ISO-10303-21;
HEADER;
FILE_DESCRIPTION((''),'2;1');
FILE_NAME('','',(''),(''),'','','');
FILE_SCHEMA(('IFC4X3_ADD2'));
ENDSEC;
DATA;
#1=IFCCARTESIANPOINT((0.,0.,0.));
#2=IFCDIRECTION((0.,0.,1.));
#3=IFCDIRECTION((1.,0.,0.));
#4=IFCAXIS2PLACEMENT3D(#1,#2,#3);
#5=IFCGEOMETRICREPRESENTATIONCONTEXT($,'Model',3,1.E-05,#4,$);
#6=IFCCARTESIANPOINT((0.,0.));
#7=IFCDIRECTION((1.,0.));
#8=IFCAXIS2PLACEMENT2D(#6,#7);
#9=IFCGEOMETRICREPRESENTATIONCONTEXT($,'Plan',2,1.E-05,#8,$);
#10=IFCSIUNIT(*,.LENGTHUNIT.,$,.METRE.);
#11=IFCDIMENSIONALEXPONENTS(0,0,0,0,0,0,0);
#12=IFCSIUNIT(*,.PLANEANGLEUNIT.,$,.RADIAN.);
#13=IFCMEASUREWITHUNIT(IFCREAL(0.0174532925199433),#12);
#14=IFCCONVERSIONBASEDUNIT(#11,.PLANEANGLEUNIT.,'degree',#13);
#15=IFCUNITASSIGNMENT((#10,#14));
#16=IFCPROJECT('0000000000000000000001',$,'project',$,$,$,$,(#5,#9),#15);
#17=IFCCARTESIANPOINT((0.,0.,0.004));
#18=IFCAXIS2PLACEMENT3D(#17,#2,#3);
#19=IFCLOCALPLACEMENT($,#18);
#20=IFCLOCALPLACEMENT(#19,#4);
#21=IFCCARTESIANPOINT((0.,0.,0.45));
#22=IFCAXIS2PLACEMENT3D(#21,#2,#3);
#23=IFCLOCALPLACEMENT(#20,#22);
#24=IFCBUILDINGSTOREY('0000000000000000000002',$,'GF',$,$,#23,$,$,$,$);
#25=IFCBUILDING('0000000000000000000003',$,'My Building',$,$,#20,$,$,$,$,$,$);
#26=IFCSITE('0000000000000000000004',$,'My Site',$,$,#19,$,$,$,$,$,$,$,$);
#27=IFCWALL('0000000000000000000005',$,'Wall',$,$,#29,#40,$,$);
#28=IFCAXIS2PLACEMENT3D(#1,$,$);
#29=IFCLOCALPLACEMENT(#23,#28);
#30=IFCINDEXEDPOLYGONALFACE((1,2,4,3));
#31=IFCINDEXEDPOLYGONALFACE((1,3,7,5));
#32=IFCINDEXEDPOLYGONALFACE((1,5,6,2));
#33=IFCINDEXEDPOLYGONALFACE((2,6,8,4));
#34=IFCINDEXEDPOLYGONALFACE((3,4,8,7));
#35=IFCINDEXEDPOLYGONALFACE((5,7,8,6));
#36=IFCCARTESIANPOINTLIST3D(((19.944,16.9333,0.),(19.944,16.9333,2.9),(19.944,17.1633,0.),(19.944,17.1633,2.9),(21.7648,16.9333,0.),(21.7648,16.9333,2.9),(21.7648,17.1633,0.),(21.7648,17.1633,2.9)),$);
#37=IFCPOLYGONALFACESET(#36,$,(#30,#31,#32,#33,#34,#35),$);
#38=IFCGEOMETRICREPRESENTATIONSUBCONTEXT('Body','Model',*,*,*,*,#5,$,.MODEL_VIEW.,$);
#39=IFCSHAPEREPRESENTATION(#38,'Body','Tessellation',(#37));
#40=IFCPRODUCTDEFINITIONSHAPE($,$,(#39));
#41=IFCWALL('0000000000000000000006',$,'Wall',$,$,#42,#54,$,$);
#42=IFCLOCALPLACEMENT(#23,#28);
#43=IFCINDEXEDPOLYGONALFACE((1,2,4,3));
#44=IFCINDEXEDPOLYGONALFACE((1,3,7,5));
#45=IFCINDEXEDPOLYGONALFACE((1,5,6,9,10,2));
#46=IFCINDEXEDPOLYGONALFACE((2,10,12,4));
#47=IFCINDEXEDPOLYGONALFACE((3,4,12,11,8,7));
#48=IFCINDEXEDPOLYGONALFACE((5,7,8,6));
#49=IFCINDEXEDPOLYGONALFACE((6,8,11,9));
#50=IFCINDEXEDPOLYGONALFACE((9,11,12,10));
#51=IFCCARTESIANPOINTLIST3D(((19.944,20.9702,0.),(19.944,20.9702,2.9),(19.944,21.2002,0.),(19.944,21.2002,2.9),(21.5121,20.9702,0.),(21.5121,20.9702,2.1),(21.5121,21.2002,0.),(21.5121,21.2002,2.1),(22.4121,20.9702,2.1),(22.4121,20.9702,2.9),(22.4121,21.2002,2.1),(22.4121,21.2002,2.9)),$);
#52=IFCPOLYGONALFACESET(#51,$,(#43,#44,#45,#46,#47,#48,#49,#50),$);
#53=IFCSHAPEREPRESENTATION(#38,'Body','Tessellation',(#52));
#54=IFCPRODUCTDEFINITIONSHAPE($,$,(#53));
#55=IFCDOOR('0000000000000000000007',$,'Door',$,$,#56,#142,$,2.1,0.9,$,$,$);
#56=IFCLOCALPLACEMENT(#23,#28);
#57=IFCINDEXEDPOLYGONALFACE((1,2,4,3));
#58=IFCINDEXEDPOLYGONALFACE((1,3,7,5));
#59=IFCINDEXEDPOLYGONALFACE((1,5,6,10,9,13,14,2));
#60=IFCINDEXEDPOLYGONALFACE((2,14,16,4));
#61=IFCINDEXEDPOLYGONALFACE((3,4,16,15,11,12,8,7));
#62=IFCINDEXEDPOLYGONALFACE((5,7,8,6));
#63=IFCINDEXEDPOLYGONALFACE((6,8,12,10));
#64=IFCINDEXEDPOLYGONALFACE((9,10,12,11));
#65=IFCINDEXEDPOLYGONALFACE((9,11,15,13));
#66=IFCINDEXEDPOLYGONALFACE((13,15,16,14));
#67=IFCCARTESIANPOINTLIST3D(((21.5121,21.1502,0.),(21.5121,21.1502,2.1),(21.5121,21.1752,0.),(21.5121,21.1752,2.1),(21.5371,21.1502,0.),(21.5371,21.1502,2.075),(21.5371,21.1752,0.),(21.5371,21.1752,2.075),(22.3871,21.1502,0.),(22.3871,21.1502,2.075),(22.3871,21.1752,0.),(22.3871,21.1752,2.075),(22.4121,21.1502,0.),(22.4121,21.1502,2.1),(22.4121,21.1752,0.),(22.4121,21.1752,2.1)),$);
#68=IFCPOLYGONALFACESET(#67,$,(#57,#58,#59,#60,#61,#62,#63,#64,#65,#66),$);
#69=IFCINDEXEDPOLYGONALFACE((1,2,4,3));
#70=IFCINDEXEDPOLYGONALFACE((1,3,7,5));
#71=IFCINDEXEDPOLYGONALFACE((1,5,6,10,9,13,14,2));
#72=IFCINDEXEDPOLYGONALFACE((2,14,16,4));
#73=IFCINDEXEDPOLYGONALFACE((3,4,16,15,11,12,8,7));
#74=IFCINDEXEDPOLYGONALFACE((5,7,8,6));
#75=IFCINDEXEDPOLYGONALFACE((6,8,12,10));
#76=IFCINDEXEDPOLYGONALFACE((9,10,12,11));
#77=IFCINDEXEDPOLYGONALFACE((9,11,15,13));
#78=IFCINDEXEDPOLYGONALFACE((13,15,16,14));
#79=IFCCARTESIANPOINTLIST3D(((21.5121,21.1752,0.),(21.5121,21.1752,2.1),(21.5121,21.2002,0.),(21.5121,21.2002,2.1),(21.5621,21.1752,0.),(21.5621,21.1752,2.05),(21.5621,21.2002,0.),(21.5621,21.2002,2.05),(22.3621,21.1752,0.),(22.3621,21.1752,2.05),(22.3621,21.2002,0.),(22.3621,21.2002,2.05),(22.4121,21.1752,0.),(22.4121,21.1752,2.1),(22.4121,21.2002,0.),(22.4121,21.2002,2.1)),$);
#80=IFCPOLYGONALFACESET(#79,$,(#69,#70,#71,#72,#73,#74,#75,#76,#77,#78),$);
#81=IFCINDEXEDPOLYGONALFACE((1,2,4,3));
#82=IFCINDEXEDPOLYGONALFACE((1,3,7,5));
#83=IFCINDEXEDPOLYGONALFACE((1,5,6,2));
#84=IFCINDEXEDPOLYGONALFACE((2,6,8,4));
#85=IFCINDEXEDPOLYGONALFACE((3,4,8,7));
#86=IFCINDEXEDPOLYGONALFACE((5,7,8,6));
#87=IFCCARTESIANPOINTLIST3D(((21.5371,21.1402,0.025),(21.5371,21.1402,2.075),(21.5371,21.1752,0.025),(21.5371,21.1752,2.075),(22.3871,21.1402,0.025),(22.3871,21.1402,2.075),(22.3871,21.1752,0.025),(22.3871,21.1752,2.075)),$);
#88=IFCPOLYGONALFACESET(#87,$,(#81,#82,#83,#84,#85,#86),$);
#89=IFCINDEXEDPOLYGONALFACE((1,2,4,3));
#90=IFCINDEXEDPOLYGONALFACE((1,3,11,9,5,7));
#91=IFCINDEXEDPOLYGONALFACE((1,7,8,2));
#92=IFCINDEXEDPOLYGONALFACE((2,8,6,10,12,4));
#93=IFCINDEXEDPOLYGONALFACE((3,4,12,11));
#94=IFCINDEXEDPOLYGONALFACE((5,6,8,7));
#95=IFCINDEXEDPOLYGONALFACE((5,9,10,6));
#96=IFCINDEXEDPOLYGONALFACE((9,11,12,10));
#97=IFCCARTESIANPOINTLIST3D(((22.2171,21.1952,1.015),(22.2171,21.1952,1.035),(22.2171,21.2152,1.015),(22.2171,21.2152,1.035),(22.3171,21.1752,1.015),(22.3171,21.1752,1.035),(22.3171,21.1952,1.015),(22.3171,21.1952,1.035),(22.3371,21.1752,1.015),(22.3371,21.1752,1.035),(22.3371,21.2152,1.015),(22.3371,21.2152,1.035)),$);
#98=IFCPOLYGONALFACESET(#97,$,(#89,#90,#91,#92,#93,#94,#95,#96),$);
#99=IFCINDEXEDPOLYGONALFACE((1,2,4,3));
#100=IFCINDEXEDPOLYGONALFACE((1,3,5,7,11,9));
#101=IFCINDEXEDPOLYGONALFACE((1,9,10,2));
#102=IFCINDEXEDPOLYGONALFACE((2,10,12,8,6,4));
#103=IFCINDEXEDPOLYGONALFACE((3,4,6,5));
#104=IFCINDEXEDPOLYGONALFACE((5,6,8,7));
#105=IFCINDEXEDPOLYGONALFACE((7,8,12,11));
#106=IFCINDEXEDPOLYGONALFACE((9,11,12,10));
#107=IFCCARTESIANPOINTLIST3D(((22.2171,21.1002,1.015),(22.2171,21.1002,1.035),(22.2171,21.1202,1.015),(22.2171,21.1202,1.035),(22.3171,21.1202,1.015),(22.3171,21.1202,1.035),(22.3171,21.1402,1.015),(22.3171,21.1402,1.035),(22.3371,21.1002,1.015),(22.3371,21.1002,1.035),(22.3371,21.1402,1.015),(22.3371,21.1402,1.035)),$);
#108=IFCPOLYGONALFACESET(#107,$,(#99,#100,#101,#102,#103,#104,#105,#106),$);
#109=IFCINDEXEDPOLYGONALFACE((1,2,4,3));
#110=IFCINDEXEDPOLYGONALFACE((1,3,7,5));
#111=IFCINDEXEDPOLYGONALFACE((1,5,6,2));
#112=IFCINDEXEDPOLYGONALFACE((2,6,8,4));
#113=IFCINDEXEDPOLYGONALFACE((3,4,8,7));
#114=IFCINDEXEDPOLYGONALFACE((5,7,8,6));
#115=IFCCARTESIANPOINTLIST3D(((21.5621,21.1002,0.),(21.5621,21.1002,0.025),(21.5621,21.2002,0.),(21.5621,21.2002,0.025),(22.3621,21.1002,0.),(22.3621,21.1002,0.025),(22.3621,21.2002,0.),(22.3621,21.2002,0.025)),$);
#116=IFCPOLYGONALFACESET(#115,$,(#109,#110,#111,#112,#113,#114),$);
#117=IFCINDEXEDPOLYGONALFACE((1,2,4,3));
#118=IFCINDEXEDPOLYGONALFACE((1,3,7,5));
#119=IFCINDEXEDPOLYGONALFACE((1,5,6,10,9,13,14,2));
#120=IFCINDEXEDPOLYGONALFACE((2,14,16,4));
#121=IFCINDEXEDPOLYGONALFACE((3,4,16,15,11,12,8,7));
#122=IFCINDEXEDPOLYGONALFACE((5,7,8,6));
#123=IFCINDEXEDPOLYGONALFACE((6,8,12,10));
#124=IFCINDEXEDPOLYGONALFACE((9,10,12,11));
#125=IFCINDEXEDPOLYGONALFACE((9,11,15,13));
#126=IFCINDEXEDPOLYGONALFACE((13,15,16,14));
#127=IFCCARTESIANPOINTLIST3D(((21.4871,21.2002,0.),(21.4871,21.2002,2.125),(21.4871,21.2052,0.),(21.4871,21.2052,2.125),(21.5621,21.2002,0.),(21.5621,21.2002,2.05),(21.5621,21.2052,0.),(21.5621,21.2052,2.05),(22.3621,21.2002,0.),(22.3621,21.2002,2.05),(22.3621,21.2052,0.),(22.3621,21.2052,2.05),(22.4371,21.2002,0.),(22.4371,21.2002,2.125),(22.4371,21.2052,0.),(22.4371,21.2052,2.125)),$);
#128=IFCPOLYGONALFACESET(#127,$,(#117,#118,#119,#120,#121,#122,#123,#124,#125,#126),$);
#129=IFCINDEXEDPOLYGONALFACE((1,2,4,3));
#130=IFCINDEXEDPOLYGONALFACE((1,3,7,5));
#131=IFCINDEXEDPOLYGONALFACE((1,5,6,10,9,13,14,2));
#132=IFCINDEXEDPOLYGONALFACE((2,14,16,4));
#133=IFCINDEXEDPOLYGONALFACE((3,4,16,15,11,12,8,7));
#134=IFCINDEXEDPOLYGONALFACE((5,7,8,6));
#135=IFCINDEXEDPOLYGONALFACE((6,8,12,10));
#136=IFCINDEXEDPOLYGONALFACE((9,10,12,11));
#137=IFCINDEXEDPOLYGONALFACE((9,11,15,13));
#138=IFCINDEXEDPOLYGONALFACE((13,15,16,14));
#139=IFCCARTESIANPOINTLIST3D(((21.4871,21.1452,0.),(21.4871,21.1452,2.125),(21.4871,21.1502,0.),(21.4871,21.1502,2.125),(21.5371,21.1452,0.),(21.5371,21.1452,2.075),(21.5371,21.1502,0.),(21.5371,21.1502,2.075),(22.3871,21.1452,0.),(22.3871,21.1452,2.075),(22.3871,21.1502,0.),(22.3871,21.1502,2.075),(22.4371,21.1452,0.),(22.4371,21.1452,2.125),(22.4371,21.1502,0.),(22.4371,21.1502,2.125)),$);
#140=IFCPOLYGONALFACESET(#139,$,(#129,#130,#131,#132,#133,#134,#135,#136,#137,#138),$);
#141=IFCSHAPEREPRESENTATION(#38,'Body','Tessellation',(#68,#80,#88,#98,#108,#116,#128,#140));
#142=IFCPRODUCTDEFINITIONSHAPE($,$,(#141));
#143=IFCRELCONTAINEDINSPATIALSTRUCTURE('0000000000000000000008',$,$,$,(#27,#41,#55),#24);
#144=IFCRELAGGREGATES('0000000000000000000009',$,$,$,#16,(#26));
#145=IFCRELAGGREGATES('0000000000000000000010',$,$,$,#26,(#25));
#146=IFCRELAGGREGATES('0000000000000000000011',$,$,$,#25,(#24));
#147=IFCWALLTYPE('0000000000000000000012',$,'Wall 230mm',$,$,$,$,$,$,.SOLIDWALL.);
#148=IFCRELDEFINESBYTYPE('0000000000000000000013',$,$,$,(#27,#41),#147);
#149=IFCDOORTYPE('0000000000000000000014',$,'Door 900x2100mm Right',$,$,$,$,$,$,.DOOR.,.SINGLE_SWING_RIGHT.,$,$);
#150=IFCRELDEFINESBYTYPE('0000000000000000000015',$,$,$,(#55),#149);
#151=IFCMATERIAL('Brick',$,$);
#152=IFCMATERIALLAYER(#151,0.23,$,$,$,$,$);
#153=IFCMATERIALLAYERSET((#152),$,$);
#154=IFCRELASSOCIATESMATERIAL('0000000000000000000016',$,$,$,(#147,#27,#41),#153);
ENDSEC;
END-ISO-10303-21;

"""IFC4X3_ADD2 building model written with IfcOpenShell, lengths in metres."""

from ifc_helpers import new_model, entity, si_unit, converted_unit, frame, origin_with_axes, origin_2d_with_axis, place, context, subcontext, project, spatial, line, indexed_curve, outline, extrude, shape, source, transform, mapped, material, layer, layer_set, layer_usage, type_object, type_shapes, element, fill, save


model = new_model("IFC4X3_ADD2")

# Units and contexts
model_context = context("Model", 3, precision=1e-05, world=origin_with_axes())
plan_context = context("Plan", 2, precision=1e-05, world=origin_2d_with_axis())
body_context_1 = subcontext(model_context, "Body", "Model", "MODEL_VIEW")
body_context_2 = subcontext(plan_context, "Body", "Plan", "PLAN_VIEW")
ifc_project = project(units=[si_unit("LENGTHUNIT", "METRE"), converted_unit("PLANEANGLEUNIT", "degree", entity("IfcReal", 0.0174532925199433), si_unit("PLANEANGLEUNIT", "RADIAN"), dimensions=[0, 0, 0, 0, 0, 0, 0])], contexts=[model_context, plan_context])

# Site, building, storey
site_placement = place(None, frame((0.0, 0.0, 0.004), z_axis=(0.0, 0.0, 1.0), x_axis=(1.0, 0.0, 0.0)))
site = spatial("IfcSite", under=ifc_project, at=site_placement, Name="My Site")
building_placement = place(site_placement, origin_with_axes())
building = spatial("IfcBuilding", under=site, at=building_placement, Name="My Building")
storey_placement = place(building_placement, frame((0.0, 0.0, 0.45), z_axis=(0.0, 0.0, 1.0), x_axis=(1.0, 0.0, 0.0)))
storey = spatial("IfcBuildingStorey", under=building, at=storey_placement, Name="GF")

# Shared definitions
ifc_material_1 = material(Name="Brick")
ifc_layer_1 = layer(ifc_material_1, 0.23)
ifc_layer_set_1 = layer_set([ifc_layer_1])
wall_type = type_object("IfcWallType", Name="Wall 230mm", PredefinedType="SOLIDWALL", material=ifc_layer_set_1)

# Wall
ifc_layer_usage_1 = layer_usage(ifc_layer_set_1, "AXIS2", "POSITIVE", 0.0)
wall_1_placement = place(storey_placement, frame((21.7648, 17.1633, 0.0), z_axis=(0.0, 0.0, 1.0), x_axis=(-1.0, 0.0, 0.0)))
element("IfcWall", 1, at=wall_1_placement, inside=storey, type_object=wall_type, material=ifc_layer_usage_1, Name="Wall", context=body_context_1, shape_type="SweptSolid", body=[
    extrude(outline(indexed_curve([(0.0, 0.0), (0.0, 0.23), (1.8208, 0.23), (1.8208, 0.0), (0.0, 0.0)], self_intersect=False)), origin_with_axes(), (0.0, 0.0, 1.0), 2.9),
])

# Wall, opening, door
ifc_layer_usage_2 = layer_usage(ifc_layer_set_1, "AXIS2", "POSITIVE", 0.0)
wall_2_placement = place(storey_placement, frame((22.4121, 21.2002, 0.0), z_axis=(0.0, 0.0, 1.0), x_axis=(-1.0, 0.0, 0.0)))
wall_2 = element("IfcWall", 2, at=wall_2_placement, inside=storey, type_object=wall_type, material=ifc_layer_usage_2, Name="Wall", context=body_context_1, shape_type="SweptSolid", body=[
    extrude(outline(indexed_curve([(0.0, 0.0), (0.0, 0.23), (2.4681, 0.23), (2.4681, 0.0), (0.0, 0.0)], self_intersect=False)), origin_with_axes(), (0.0, 0.0, 1.0), 2.9),
])
shared_shape_1 = source(origin_with_axes(), body_context_1, "Body", "SweptSolid", [
    extrude(outline(indexed_curve([(0.0, 0.0), (0.9, 0.0), (0.9, 2.1), (0.0, 2.1)], segments=[line(1, 2, 3, 4, 1)])), frame((0.0, -0.6, 0.0), z_axis=(0.0, -1.0, 0.0), x_axis=(1.0, 0.0, 0.0)), (0.0, 0.0, -1.0), 1.2),
])
opening_1_placement = place(wall_2_placement, frame((0.0, 0.0, 0.0), z_axis=(0.0, 0.0, 1.0), x_axis=(1.0, 0.0, 0.0)))
opening_1 = element("IfcOpeningElement", 3, at=opening_1_placement, cuts=wall_2, PredefinedType="OPENING", context=body_context_1, shape_type="MappedRepresentation", body=[
    mapped(shared_shape_1, transform((0.0, 0.0, 0.0), x_axis=(1.0, 0.0, 0.0), y_axis=(0.0, 1.0, 0.0), z_axis=(0.0, 0.0, 1.0), scale=1.0)),
])
door_type_1 = type_object("IfcDoorType", Name="Door 900x2100mm Right", OperationType="SINGLE_SWING_RIGHT", PredefinedType="DOOR")
shared_shape_2 = source(origin_with_axes(), body_context_1, "Body", "SweptSolid", [
    extrude(outline(indexed_curve([(0.0, 0.0), (0.0, 2.1), (0.9, 2.1), (0.9, 0.0), (0.875, 0.0), (0.875, 2.075), (0.025, 2.075), (0.025, 0.0)], segments=[line(1, 2, 3, 4, 5, 6, 7, 8, 1)])), frame((0.0, 0.025, 0.0), z_axis=(0.0, -1.0, 0.0), x_axis=(1.0, 0.0, 0.0)), (0.0, 0.0, -1.0), 0.025),
    extrude(outline(indexed_curve([(0.0, 0.0), (0.0, 2.1), (0.9, 2.1), (0.9, 0.0), (0.85, 0.0), (0.85, 2.05), (0.05, 2.05), (0.05, 0.0)], segments=[line(1, 2, 3, 4, 5, 6, 7, 8, 1)])), frame((0.0, 0.0, 0.0), z_axis=(0.0, -1.0, 0.0), x_axis=(1.0, 0.0, 0.0)), (0.0, 0.0, -1.0), 0.025),
    extrude(outline(indexed_curve([(0.0, 0.0), (0.85, 0.0), (0.85, 0.035), (0.0, 0.035)], segments=[line(1, 2, 3, 4, 1)])), frame((0.025, 0.025, 0.025), z_axis=(0.0, 0.0, 1.0), x_axis=(1.0, 0.0, 0.0)), (0.0, 0.0, 1.0), 2.05),
    extrude(outline(indexed_curve([(0.0, 0.0), (0.0, -0.04), (0.12, -0.04), (0.12, -0.02), (0.02, -0.02), (0.02, 0.0)], segments=[line(1, 2, 3, 4, 5, 6, 1)])), frame((0.075, 0.025, 1.015), z_axis=(0.0, 0.0, 1.0), x_axis=(1.0, 0.0, 0.0)), (0.0, 0.0, 1.0), 0.02),
    extrude(outline(indexed_curve([(0.0, 0.0), (0.0, 0.04), (0.12, 0.04), (0.12, 0.02), (0.02, 0.02), (0.02, 0.0)], segments=[line(1, 2, 3, 4, 5, 6, 1)])), frame((0.075, 0.06, 1.015), z_axis=(0.0, 0.0, 1.0), x_axis=(1.0, 0.0, 0.0)), (0.0, 0.0, 1.0), 0.02),
    extrude(outline(indexed_curve([(0.0, 0.0), (0.8, 0.0), (0.8, 0.1), (0.0, 0.1)], segments=[line(1, 2, 3, 4, 1)])), frame((0.05, 0.0, 0.0), z_axis=(0.0, 0.0, 1.0), x_axis=(1.0, 0.0, 0.0)), (0.0, 0.0, 1.0), 0.025),
    extrude(outline(indexed_curve([(0.0, 0.0), (0.0, 2.125), (0.95, 2.125), (0.95, 0.0), (0.875, 0.0), (0.875, 2.05), (0.075, 2.05), (0.075, 0.0)], segments=[line(1, 2, 3, 4, 5, 6, 7, 8, 1)])), frame((-0.025, -0.005, 0.0), z_axis=(0.0, -1.0, 0.0), x_axis=(1.0, 0.0, 0.0)), (0.0, 0.0, -1.0), 0.005),
    extrude(outline(indexed_curve([(0.0, 0.0), (0.0, 2.125), (0.95, 2.125), (0.95, 0.0), (0.9, 0.0), (0.9, 2.075), (0.05, 2.075), (0.05, 0.0)], segments=[line(1, 2, 3, 4, 5, 6, 7, 8, 1)])), frame((-0.025, 0.05, 0.0), z_axis=(0.0, -1.0, 0.0), x_axis=(1.0, 0.0, 0.0)), (0.0, 0.0, -1.0), 0.005),
])
shared_shape_3 = source(origin_with_axes(), body_context_2, "Body", "Curve2D", [
    entity("IfcIndexedPolyCurve", entity("IfcCartesianPointList2D", [[0.0, 0.0], [0.0, 0.05], [0.025, 0.05], [0.025, 0.025], [0.05, 0.025], [0.05, 0.0]]), [entity("IfcLineIndex", [1, 2, 3, 4, 5, 6, 1])]),
    entity("IfcIndexedPolyCurve", entity("IfcCartesianPointList2D", [[0.9, 0.0], [0.9, 0.05], [0.875, 0.05], [0.875, 0.025], [0.85, 0.025], [0.85, 0.0]]), [entity("IfcLineIndex", [1, 2, 3, 4, 5, 6, 1])]),
    entity("IfcTrimmedCurve", entity("IfcEllipse", entity("IfcAxis2Placement2D", entity("IfcCartesianPoint", [0.84, 0.05]), entity("IfcDirection", [1.0, 0.0])), 0.815, 0.85), [entity("IfcCartesianPoint", [0.84, 0.9])], [entity("IfcCartesianPoint", [0.025, 0.05])], True, "CARTESIAN"),
    entity("IfcIndexedPolyCurve", entity("IfcCartesianPointList2D", [[0.875, 0.05], [0.84, 0.05], [0.84, 0.9], [0.875, 0.9]]), [entity("IfcLineIndex", [1, 2, 3, 4, 1])]),
])
type_shapes(door_type_1, [shared_shape_2, shared_shape_3])
door_1_placement = place(opening_1_placement, origin_with_axes())
door_1 = element("IfcDoor", 4, at=door_1_placement, inside=storey, type_object=door_type_1, Name="Door", OverallHeight=2.1, OverallWidth=0.9, shapes=[
    shape(body_context_1, "Body", "MappedRepresentation", [mapped(shared_shape_2, transform((0.0, 0.0, 0.0), x_axis=(1.0, 0.0, 0.0), y_axis=(0.0, 1.0, 0.0), z_axis=(0.0, 0.0, 1.0), scale=1.0))]),
    shape(body_context_2, "Body", "MappedRepresentation", [mapped(shared_shape_3, transform((0.0, 0.0, 0.0), x_axis=(1.0, 0.0, 0.0), y_axis=(0.0, 1.0, 0.0), z_axis=(0.0, 0.0, 1.0), scale=1.0))]),
])
fill(opening_1, door_1)

save(model, "model.ifc")
